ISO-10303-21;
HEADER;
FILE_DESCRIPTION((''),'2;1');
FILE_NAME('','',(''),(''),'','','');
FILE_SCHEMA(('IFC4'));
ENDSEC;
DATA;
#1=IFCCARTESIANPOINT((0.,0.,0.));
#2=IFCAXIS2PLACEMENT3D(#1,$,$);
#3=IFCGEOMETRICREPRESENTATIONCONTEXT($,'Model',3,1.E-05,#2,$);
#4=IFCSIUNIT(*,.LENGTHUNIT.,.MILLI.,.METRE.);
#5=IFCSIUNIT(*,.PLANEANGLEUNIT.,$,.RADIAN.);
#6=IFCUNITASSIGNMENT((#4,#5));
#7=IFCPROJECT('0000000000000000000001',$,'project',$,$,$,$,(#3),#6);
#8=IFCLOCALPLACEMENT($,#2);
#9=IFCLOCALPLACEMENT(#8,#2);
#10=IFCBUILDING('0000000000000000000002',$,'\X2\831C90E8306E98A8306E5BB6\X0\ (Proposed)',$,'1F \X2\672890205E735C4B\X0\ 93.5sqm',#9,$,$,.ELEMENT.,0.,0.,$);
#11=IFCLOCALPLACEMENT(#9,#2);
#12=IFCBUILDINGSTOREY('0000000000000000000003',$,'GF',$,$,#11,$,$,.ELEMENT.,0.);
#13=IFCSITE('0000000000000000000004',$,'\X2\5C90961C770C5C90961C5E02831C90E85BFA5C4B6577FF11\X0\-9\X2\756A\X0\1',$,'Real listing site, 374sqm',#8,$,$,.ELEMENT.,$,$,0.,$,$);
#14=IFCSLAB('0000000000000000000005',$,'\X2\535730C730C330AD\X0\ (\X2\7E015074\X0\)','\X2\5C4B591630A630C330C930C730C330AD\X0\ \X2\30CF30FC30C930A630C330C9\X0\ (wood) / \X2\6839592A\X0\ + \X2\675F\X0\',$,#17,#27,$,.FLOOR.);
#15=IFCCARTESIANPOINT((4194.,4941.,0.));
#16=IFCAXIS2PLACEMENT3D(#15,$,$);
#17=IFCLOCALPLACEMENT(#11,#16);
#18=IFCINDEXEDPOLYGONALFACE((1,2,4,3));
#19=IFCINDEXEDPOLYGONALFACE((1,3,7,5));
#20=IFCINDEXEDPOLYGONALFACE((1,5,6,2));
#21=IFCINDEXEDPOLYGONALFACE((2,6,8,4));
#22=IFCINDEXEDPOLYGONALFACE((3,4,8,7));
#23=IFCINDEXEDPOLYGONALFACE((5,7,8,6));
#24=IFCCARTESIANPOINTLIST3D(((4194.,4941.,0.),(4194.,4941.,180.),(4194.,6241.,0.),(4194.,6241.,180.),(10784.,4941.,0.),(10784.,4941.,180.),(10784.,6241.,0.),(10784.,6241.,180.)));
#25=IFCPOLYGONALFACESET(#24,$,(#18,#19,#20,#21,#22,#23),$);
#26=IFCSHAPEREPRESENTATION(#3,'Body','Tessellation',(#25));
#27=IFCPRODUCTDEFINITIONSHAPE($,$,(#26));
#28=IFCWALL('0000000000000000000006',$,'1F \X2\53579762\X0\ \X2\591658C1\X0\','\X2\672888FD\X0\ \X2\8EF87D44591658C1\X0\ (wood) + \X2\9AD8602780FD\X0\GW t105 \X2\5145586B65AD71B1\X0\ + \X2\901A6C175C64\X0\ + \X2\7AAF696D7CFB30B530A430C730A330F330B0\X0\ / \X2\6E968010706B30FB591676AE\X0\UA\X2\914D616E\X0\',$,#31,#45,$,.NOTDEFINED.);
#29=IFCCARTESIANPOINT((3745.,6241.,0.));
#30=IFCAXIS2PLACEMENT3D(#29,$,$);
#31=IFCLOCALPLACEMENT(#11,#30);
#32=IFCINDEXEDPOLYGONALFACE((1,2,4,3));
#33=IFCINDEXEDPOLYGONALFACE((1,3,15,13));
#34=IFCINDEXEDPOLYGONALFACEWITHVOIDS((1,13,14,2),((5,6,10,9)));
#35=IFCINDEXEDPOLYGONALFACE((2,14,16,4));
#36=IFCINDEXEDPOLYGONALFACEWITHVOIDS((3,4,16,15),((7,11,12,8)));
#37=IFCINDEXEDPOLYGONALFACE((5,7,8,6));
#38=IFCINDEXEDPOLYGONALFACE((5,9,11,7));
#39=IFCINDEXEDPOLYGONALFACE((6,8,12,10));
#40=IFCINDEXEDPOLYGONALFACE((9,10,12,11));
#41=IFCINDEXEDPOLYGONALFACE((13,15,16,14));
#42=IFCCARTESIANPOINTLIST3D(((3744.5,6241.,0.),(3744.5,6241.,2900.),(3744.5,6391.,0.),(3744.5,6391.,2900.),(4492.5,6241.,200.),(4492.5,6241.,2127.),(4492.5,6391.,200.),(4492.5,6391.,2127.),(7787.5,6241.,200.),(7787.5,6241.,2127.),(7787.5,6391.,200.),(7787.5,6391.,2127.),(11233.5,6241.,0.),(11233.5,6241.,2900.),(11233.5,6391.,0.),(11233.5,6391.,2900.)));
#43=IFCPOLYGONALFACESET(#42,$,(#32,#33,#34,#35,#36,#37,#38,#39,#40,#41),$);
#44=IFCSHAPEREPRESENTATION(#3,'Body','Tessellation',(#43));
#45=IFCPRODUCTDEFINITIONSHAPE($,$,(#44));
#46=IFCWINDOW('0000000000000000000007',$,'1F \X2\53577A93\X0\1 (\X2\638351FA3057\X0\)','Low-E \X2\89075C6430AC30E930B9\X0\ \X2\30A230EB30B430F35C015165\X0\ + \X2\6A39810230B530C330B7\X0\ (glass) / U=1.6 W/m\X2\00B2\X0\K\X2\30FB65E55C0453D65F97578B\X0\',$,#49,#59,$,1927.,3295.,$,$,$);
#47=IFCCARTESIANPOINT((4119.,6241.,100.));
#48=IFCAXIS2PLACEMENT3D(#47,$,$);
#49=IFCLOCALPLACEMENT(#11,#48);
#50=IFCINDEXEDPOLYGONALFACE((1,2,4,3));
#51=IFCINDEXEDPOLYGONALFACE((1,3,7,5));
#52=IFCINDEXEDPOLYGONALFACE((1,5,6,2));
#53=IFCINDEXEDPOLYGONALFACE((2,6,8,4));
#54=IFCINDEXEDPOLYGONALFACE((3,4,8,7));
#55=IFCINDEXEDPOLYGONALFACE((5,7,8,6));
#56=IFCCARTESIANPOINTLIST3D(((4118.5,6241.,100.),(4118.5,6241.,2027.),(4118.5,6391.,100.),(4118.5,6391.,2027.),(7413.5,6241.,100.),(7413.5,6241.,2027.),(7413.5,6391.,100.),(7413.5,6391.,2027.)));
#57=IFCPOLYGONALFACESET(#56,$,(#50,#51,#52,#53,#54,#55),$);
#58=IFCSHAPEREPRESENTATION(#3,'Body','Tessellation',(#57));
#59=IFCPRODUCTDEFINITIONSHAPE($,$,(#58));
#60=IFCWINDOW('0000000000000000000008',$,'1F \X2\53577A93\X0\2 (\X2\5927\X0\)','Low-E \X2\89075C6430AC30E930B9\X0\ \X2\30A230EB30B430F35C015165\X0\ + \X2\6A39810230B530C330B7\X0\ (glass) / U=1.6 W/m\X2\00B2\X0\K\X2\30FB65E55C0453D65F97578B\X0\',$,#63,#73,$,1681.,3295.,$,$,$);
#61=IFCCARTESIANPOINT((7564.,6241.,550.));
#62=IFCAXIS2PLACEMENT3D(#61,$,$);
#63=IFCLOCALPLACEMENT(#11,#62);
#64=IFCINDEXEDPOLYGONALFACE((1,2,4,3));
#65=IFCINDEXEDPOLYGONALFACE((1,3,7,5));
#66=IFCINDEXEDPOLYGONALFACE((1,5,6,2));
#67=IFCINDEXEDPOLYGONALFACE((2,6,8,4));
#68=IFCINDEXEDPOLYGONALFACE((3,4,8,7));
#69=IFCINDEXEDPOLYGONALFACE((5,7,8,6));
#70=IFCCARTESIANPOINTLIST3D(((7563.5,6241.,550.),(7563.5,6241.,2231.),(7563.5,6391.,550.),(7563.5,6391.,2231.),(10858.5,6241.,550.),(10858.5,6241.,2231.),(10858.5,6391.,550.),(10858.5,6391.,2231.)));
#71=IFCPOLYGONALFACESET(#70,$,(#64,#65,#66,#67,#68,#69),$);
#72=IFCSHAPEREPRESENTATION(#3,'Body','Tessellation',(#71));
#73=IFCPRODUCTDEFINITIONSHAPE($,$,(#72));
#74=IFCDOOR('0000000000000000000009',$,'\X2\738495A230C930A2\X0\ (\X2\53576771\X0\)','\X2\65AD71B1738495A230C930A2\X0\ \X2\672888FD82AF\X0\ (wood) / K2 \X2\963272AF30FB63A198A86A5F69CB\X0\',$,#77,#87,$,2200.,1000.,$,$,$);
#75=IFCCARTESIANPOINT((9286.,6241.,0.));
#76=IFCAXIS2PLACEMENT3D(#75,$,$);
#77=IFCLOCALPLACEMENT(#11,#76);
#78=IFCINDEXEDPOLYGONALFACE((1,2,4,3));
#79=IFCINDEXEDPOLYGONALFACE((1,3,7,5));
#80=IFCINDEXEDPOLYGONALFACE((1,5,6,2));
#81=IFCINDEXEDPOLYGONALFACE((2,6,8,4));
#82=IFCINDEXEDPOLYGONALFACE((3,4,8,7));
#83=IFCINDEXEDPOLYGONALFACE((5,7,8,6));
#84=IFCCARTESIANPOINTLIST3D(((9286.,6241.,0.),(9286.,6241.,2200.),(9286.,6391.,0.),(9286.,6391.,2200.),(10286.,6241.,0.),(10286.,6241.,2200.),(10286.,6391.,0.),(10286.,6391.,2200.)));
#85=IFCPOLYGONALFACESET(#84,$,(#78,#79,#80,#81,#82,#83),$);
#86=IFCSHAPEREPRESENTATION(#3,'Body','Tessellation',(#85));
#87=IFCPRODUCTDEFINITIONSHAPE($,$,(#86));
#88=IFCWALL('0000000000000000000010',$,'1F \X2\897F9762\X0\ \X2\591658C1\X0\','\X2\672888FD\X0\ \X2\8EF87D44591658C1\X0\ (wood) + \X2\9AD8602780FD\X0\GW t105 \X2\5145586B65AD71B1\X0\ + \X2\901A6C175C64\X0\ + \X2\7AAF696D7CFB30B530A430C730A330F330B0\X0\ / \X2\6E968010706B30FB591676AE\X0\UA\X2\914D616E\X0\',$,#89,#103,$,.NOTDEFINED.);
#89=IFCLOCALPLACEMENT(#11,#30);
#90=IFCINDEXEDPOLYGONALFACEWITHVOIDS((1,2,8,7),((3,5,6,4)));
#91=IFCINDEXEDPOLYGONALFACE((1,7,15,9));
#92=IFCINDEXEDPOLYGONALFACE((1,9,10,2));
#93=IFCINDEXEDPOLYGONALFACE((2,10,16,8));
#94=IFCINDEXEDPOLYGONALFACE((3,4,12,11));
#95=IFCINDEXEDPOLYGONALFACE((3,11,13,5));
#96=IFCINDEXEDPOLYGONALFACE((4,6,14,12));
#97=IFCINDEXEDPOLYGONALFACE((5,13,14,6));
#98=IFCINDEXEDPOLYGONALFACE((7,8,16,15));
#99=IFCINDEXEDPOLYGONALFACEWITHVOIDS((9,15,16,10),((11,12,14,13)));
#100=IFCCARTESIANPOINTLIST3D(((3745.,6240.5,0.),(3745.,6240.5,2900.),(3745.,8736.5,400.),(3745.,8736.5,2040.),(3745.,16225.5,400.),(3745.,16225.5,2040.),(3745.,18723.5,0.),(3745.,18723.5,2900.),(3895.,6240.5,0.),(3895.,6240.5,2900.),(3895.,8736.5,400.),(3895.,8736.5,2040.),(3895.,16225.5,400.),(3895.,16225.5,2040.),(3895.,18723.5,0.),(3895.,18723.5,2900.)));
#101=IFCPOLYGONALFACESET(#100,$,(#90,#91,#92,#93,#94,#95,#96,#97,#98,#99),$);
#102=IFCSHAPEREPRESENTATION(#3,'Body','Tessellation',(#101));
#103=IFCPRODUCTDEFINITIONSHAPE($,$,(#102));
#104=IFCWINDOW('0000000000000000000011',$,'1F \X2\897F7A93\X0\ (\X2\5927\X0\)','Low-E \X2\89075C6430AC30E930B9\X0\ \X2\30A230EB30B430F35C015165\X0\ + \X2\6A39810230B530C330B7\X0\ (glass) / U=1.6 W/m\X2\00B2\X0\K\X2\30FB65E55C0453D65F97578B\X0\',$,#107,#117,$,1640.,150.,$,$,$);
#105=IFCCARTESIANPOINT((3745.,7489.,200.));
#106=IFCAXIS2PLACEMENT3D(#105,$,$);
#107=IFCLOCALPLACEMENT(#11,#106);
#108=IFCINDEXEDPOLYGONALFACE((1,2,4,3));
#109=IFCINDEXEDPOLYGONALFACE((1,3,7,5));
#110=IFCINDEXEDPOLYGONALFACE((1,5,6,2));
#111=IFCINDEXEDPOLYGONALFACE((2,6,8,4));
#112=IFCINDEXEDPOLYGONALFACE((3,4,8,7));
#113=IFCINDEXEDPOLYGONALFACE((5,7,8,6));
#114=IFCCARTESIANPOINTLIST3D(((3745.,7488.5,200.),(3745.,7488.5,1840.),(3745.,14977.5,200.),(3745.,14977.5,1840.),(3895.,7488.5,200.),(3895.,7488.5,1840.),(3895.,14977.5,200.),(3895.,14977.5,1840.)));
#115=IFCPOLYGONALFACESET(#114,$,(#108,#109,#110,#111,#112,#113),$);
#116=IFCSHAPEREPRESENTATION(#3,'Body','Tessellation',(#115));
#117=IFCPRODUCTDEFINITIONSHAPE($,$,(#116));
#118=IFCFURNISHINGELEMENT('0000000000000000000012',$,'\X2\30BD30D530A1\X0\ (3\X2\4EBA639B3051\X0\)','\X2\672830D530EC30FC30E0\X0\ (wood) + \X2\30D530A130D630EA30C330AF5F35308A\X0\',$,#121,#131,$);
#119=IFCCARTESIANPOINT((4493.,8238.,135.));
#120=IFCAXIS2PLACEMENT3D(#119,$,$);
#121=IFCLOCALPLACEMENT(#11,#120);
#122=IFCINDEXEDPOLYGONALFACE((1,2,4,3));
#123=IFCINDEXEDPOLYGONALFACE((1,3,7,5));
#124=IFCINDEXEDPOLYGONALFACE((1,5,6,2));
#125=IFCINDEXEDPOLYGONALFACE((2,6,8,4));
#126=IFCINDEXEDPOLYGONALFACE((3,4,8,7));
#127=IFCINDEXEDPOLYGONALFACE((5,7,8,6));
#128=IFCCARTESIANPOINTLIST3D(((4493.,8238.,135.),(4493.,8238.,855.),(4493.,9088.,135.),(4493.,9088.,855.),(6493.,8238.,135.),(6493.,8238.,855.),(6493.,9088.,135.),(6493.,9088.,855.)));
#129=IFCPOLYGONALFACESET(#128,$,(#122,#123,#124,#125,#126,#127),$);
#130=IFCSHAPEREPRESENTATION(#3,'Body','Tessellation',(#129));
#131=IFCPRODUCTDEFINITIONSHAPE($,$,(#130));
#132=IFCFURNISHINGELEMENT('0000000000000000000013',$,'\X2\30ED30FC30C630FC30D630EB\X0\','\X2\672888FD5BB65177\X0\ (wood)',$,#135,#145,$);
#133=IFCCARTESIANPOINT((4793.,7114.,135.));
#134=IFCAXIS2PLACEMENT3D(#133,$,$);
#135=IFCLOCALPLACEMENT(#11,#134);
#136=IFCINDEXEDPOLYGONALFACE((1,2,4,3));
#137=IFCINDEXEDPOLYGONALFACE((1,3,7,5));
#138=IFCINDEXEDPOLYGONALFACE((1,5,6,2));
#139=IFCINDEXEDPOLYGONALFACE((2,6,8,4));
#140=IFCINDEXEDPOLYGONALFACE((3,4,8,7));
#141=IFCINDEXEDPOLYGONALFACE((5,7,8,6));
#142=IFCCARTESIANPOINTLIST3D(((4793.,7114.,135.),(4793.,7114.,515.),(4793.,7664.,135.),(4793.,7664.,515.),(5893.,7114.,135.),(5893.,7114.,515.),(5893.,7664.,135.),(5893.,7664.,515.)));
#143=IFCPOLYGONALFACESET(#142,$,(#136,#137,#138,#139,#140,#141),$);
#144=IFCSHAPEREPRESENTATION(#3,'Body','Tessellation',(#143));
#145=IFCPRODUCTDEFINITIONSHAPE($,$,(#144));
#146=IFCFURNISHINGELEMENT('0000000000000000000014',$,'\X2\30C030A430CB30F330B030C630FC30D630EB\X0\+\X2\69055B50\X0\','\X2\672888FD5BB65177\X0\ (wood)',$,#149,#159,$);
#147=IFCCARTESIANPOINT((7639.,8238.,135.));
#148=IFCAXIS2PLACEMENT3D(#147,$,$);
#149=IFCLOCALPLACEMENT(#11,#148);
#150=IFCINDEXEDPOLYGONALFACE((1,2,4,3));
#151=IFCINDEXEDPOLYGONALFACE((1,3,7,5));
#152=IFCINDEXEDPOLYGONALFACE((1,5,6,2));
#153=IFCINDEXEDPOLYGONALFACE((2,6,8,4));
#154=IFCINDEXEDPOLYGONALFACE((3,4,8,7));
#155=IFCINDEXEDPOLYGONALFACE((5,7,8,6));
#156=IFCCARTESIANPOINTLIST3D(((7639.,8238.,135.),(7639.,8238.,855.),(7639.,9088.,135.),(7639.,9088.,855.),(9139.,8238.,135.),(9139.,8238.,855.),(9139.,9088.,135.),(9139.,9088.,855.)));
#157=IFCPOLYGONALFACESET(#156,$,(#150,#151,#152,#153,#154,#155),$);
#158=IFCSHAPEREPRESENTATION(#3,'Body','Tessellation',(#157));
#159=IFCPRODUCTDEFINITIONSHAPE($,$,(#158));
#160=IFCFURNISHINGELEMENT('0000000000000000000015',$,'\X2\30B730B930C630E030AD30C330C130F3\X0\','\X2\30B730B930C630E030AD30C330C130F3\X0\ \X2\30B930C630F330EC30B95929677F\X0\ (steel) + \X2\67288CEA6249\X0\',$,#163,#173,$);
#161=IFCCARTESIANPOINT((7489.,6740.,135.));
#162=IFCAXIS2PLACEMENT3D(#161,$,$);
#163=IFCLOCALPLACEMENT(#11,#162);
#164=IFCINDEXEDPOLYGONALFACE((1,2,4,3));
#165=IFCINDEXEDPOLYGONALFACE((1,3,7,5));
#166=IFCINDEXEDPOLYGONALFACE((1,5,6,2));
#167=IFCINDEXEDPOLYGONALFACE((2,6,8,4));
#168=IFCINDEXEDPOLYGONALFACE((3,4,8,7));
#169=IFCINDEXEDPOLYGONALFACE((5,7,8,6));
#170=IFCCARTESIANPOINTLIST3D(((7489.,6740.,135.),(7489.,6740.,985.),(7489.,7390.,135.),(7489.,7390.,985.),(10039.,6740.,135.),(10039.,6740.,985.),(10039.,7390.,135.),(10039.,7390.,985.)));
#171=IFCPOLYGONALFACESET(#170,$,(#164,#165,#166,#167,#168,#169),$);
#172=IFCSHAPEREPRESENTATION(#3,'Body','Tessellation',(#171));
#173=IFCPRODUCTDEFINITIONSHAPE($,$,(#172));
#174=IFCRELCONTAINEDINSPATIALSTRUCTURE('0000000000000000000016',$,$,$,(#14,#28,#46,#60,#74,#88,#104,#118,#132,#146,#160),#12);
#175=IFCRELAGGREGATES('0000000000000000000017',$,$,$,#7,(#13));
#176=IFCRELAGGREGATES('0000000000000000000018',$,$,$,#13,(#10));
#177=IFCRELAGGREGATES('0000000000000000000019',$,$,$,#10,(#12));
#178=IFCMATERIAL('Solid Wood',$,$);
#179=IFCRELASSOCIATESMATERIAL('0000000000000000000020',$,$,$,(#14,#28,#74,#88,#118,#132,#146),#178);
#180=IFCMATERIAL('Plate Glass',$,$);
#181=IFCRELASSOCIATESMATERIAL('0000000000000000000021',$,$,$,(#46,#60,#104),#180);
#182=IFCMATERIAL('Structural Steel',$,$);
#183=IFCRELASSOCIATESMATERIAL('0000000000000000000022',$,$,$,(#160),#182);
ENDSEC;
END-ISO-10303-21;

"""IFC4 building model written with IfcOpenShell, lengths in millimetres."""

from ifc_helpers import new_model, si_unit, frame, frame_2d, origin, place, context, project, spatial, rectangle, extrude, material, element, fill, save


model = new_model("IFC4")

# Units and contexts
model_context = context("Model", 3, precision=1e-05, world=origin())
ifc_project = project(units=[si_unit("LENGTHUNIT", "METRE", prefix="MILLI"), si_unit("PLANEANGLEUNIT", "RADIAN")], contexts=[model_context])

# Site, building, storey
site_placement = place(None, origin())
site = spatial("IfcSite", under=ifc_project, at=site_placement, Name="岐阜県岐阜市茜部寺屋敷１-9番1", ObjectType="Real listing site, 374sqm", CompositionType="ELEMENT", RefElevation=0.0)
building_placement = place(site_placement, origin())
building = spatial("IfcBuilding", under=site, at=building_placement, Name="茜部の風の家 (Proposed)", ObjectType="1F 木造平屋 93.5sqm", CompositionType="ELEMENT", ElevationOfRefHeight=0.0, ElevationOfTerrain=0.0)
storey_placement = place(building_placement, origin())
storey = spatial("IfcBuildingStorey", under=building, at=storey_placement, Name="GF", CompositionType="ELEMENT", Elevation=0.0)

# Slab
ifc_material_1 = material(Name="Solid Wood")
slab_1_placement = place(storey_placement, frame((4194.0, 4941.0, 0.0)))
element("IfcSlab", 1, at=slab_1_placement, inside=storey, material=ifc_material_1, Name="南デッキ (縁側)", Description="屋外ウッドデッキ ハードウッド (wood) / 根太 + 束", PredefinedType="FLOOR", context=model_context, shape_type="SweptSolid", body=[
    extrude(rectangle(XDim=6590.0, YDim=1300.0, at=frame_2d((3295.0, 650.0))), frame((4194.0, 4941.0, 0.0)), (0.0, 0.0, 1.0), 180.0),
])

# Wall, openings, windows, door
wall_1_placement = place(storey_placement, frame((3745.0, 6241.0, 0.0)))
wall_1 = element("IfcWall", 2, at=wall_1_placement, inside=storey, material=ifc_material_1, Name="1F 南面 外壁", Description="木製 軸組外壁 (wood) + 高性能GW t105 充填断熱 + 通気層 + 窯業系サイディング / 準耐火・外皮UA配慮", PredefinedType="NOTDEFINED", context=model_context, shape_type="SweptSolid", body=[
    extrude(rectangle(XDim=7489.0, YDim=150.0, at=frame_2d((3744.0, 75.0))), frame((3745.0, 6241.0, 0.0)), (0.0, 0.0, 1.0), 2900.0),
])
opening_1_placement = place(storey_placement, frame((4119.0, 6241.0, 100.0)))
opening_1 = element("IfcOpeningElement", 3, at=opening_1_placement, cuts=wall_1, PredefinedType="NOTDEFINED", context=model_context, shape_type="SweptSolid", body=[
    extrude(rectangle(XDim=3295.0, YDim=150.0, at=frame_2d((1647.0, 75.0))), frame((4119.0, 6241.0, 100.0)), (0.0, 0.0, 1.0), 1927.0),
])
opening_2_placement = place(storey_placement, frame((7564.0, 6241.0, 550.0)))
opening_2 = element("IfcOpeningElement", 4, at=opening_2_placement, cuts=wall_1, PredefinedType="NOTDEFINED", context=model_context, shape_type="SweptSolid", body=[
    extrude(rectangle(XDim=3295.0, YDim=150.0, at=frame_2d((1647.0, 75.0))), frame((7564.0, 6241.0, 550.0)), (0.0, 0.0, 1.0), 1681.0),
])
opening_3_placement = place(storey_placement, frame((9286.0, 6241.0, 0.0)))
opening_3 = element("IfcOpeningElement", 5, at=opening_3_placement, cuts=wall_1, PredefinedType="NOTDEFINED", context=model_context, shape_type="SweptSolid", body=[
    extrude(rectangle(XDim=1000.0, YDim=150.0, at=frame_2d((500.0, 75.0))), frame((9286.0, 6241.0, 0.0)), (0.0, 0.0, 1.0), 2200.0),
])
ifc_material_2 = material(Name="Plate Glass")
window_1_placement = place(storey_placement, frame((4119.0, 6241.0, 100.0)))
window_1 = element("IfcWindow", 6, at=window_1_placement, inside=storey, material=ifc_material_2, Name="1F 南窓1 (掃出し)", Description="Low-E 複層ガラス アルゴン封入 + 樹脂サッシ (glass) / U=1.6 W/m²K・日射取得型", OverallHeight=1927.0, OverallWidth=3295.0, context=model_context, shape_type="SweptSolid", body=[
    extrude(rectangle(XDim=3295.0, YDim=150.0, at=frame_2d((1647.0, 75.0))), frame((4119.0, 6241.0, 100.0)), (0.0, 0.0, 1.0), 1927.0),
])
fill(opening_1, window_1)
window_2_placement = place(storey_placement, frame((7564.0, 6241.0, 550.0)))
window_2 = element("IfcWindow", 7, at=window_2_placement, inside=storey, material=ifc_material_2, Name="1F 南窓2 (大)", Description="Low-E 複層ガラス アルゴン封入 + 樹脂サッシ (glass) / U=1.6 W/m²K・日射取得型", OverallHeight=1681.0, OverallWidth=3295.0, context=model_context, shape_type="SweptSolid", body=[
    extrude(rectangle(XDim=3295.0, YDim=150.0, at=frame_2d((1647.0, 75.0))), frame((7564.0, 6241.0, 550.0)), (0.0, 0.0, 1.0), 1681.0),
])
fill(opening_2, window_2)
door_placement = place(storey_placement, frame((9286.0, 6241.0, 0.0)))
door = element("IfcDoor", 8, at=door_placement, inside=storey, material=ifc_material_1, Name="玄関ドア (南東)", Description="断熱玄関ドア 木製芯 (wood) / K2 防犯・採風機構", OverallHeight=2200.0, OverallWidth=1000.0, context=model_context, shape_type="SweptSolid", body=[
    extrude(rectangle(XDim=1000.0, YDim=150.0, at=frame_2d((500.0, 75.0))), frame((9286.0, 6241.0, 0.0)), (0.0, 0.0, 1.0), 2200.0),
])
fill(opening_3, door)

# Wall, opening, window
wall_2_placement = place(storey_placement, frame((3745.0, 6241.0, 0.0)))
wall_2 = element("IfcWall", 9, at=wall_2_placement, inside=storey, material=ifc_material_1, Name="1F 西面 外壁", Description="木製 軸組外壁 (wood) + 高性能GW t105 充填断熱 + 通気層 + 窯業系サイディング / 準耐火・外皮UA配慮", PredefinedType="NOTDEFINED", context=model_context, shape_type="SweptSolid", body=[
    extrude(rectangle(XDim=150.0, YDim=12483.0, at=frame_2d((75.0, 6241.0))), frame((3745.0, 6241.0, 0.0)), (0.0, 0.0, 1.0), 2900.0),
])
opening_4_placement = place(storey_placement, frame((3745.0, 7489.0, 200.0)))
opening_4 = element("IfcOpeningElement", 10, at=opening_4_placement, cuts=wall_2, PredefinedType="NOTDEFINED", context=model_context, shape_type="SweptSolid", body=[
    extrude(rectangle(XDim=150.0, YDim=7489.0, at=frame_2d((75.0, 3744.0))), frame((3745.0, 7489.0, 200.0)), (0.0, 0.0, 1.0), 1640.0),
])
window_3_placement = place(storey_placement, frame((3745.0, 7489.0, 200.0)))
window_3 = element("IfcWindow", 11, at=window_3_placement, inside=storey, material=ifc_material_2, Name="1F 西窓 (大)", Description="Low-E 複層ガラス アルゴン封入 + 樹脂サッシ (glass) / U=1.6 W/m²K・日射取得型", OverallHeight=1640.0, OverallWidth=150.0, context=model_context, shape_type="SweptSolid", body=[
    extrude(rectangle(XDim=150.0, YDim=7489.0, at=frame_2d((75.0, 3744.0))), frame((3745.0, 7489.0, 200.0)), (0.0, 0.0, 1.0), 1640.0),
])
fill(opening_4, window_3)

# Shared definitions
ifc_material_3 = material(Name="Structural Steel")

# Furnishing elements
furnishing_1_placement = place(storey_placement, frame((4493.0, 8238.0, 135.0)))
element("IfcFurnishingElement", 12, at=furnishing_1_placement, inside=storey, material=ifc_material_1, Name="ソファ (3人掛け)", Description="木フレーム (wood) + ファブリック張り", context=model_context, shape_type="SweptSolid", body=[
    extrude(rectangle(XDim=2000.0, YDim=850.0, at=frame_2d((1000.0, 425.0))), frame((4493.0, 8238.0, 135.0)), (0.0, 0.0, 1.0), 720.0),
])
furnishing_2_placement = place(storey_placement, frame((4793.0, 7114.0, 135.0)))
element("IfcFurnishingElement", 13, at=furnishing_2_placement, inside=storey, material=ifc_material_1, Name="ローテーブル", Description="木製家具 (wood)", context=model_context, shape_type="SweptSolid", body=[
    extrude(rectangle(XDim=1100.0, YDim=550.0, at=frame_2d((550.0, 275.0))), frame((4793.0, 7114.0, 135.0)), (0.0, 0.0, 1.0), 380.0),
])
furnishing_3_placement = place(storey_placement, frame((7639.0, 8238.0, 135.0)))
element("IfcFurnishingElement", 14, at=furnishing_3_placement, inside=storey, material=ifc_material_1, Name="ダイニングテーブル+椅子", Description="木製家具 (wood)", context=model_context, shape_type="SweptSolid", body=[
    extrude(rectangle(XDim=1500.0, YDim=850.0, at=frame_2d((750.0, 425.0))), frame((7639.0, 8238.0, 135.0)), (0.0, 0.0, 1.0), 720.0),
])
furnishing_4_placement = place(storey_placement, frame((7489.0, 6740.0, 135.0)))
element("IfcFurnishingElement", 15, at=furnishing_4_placement, inside=storey, material=ifc_material_3, Name="システムキッチン", Description="システムキッチン ステンレス天板 (steel) + 木質扉", context=model_context, shape_type="SweptSolid", body=[
    extrude(rectangle(XDim=2550.0, YDim=650.0, at=frame_2d((1275.0, 325.0))), frame((7489.0, 6740.0, 135.0)), (0.0, 0.0, 1.0), 850.0),
])

save(model, "model.ifc")
